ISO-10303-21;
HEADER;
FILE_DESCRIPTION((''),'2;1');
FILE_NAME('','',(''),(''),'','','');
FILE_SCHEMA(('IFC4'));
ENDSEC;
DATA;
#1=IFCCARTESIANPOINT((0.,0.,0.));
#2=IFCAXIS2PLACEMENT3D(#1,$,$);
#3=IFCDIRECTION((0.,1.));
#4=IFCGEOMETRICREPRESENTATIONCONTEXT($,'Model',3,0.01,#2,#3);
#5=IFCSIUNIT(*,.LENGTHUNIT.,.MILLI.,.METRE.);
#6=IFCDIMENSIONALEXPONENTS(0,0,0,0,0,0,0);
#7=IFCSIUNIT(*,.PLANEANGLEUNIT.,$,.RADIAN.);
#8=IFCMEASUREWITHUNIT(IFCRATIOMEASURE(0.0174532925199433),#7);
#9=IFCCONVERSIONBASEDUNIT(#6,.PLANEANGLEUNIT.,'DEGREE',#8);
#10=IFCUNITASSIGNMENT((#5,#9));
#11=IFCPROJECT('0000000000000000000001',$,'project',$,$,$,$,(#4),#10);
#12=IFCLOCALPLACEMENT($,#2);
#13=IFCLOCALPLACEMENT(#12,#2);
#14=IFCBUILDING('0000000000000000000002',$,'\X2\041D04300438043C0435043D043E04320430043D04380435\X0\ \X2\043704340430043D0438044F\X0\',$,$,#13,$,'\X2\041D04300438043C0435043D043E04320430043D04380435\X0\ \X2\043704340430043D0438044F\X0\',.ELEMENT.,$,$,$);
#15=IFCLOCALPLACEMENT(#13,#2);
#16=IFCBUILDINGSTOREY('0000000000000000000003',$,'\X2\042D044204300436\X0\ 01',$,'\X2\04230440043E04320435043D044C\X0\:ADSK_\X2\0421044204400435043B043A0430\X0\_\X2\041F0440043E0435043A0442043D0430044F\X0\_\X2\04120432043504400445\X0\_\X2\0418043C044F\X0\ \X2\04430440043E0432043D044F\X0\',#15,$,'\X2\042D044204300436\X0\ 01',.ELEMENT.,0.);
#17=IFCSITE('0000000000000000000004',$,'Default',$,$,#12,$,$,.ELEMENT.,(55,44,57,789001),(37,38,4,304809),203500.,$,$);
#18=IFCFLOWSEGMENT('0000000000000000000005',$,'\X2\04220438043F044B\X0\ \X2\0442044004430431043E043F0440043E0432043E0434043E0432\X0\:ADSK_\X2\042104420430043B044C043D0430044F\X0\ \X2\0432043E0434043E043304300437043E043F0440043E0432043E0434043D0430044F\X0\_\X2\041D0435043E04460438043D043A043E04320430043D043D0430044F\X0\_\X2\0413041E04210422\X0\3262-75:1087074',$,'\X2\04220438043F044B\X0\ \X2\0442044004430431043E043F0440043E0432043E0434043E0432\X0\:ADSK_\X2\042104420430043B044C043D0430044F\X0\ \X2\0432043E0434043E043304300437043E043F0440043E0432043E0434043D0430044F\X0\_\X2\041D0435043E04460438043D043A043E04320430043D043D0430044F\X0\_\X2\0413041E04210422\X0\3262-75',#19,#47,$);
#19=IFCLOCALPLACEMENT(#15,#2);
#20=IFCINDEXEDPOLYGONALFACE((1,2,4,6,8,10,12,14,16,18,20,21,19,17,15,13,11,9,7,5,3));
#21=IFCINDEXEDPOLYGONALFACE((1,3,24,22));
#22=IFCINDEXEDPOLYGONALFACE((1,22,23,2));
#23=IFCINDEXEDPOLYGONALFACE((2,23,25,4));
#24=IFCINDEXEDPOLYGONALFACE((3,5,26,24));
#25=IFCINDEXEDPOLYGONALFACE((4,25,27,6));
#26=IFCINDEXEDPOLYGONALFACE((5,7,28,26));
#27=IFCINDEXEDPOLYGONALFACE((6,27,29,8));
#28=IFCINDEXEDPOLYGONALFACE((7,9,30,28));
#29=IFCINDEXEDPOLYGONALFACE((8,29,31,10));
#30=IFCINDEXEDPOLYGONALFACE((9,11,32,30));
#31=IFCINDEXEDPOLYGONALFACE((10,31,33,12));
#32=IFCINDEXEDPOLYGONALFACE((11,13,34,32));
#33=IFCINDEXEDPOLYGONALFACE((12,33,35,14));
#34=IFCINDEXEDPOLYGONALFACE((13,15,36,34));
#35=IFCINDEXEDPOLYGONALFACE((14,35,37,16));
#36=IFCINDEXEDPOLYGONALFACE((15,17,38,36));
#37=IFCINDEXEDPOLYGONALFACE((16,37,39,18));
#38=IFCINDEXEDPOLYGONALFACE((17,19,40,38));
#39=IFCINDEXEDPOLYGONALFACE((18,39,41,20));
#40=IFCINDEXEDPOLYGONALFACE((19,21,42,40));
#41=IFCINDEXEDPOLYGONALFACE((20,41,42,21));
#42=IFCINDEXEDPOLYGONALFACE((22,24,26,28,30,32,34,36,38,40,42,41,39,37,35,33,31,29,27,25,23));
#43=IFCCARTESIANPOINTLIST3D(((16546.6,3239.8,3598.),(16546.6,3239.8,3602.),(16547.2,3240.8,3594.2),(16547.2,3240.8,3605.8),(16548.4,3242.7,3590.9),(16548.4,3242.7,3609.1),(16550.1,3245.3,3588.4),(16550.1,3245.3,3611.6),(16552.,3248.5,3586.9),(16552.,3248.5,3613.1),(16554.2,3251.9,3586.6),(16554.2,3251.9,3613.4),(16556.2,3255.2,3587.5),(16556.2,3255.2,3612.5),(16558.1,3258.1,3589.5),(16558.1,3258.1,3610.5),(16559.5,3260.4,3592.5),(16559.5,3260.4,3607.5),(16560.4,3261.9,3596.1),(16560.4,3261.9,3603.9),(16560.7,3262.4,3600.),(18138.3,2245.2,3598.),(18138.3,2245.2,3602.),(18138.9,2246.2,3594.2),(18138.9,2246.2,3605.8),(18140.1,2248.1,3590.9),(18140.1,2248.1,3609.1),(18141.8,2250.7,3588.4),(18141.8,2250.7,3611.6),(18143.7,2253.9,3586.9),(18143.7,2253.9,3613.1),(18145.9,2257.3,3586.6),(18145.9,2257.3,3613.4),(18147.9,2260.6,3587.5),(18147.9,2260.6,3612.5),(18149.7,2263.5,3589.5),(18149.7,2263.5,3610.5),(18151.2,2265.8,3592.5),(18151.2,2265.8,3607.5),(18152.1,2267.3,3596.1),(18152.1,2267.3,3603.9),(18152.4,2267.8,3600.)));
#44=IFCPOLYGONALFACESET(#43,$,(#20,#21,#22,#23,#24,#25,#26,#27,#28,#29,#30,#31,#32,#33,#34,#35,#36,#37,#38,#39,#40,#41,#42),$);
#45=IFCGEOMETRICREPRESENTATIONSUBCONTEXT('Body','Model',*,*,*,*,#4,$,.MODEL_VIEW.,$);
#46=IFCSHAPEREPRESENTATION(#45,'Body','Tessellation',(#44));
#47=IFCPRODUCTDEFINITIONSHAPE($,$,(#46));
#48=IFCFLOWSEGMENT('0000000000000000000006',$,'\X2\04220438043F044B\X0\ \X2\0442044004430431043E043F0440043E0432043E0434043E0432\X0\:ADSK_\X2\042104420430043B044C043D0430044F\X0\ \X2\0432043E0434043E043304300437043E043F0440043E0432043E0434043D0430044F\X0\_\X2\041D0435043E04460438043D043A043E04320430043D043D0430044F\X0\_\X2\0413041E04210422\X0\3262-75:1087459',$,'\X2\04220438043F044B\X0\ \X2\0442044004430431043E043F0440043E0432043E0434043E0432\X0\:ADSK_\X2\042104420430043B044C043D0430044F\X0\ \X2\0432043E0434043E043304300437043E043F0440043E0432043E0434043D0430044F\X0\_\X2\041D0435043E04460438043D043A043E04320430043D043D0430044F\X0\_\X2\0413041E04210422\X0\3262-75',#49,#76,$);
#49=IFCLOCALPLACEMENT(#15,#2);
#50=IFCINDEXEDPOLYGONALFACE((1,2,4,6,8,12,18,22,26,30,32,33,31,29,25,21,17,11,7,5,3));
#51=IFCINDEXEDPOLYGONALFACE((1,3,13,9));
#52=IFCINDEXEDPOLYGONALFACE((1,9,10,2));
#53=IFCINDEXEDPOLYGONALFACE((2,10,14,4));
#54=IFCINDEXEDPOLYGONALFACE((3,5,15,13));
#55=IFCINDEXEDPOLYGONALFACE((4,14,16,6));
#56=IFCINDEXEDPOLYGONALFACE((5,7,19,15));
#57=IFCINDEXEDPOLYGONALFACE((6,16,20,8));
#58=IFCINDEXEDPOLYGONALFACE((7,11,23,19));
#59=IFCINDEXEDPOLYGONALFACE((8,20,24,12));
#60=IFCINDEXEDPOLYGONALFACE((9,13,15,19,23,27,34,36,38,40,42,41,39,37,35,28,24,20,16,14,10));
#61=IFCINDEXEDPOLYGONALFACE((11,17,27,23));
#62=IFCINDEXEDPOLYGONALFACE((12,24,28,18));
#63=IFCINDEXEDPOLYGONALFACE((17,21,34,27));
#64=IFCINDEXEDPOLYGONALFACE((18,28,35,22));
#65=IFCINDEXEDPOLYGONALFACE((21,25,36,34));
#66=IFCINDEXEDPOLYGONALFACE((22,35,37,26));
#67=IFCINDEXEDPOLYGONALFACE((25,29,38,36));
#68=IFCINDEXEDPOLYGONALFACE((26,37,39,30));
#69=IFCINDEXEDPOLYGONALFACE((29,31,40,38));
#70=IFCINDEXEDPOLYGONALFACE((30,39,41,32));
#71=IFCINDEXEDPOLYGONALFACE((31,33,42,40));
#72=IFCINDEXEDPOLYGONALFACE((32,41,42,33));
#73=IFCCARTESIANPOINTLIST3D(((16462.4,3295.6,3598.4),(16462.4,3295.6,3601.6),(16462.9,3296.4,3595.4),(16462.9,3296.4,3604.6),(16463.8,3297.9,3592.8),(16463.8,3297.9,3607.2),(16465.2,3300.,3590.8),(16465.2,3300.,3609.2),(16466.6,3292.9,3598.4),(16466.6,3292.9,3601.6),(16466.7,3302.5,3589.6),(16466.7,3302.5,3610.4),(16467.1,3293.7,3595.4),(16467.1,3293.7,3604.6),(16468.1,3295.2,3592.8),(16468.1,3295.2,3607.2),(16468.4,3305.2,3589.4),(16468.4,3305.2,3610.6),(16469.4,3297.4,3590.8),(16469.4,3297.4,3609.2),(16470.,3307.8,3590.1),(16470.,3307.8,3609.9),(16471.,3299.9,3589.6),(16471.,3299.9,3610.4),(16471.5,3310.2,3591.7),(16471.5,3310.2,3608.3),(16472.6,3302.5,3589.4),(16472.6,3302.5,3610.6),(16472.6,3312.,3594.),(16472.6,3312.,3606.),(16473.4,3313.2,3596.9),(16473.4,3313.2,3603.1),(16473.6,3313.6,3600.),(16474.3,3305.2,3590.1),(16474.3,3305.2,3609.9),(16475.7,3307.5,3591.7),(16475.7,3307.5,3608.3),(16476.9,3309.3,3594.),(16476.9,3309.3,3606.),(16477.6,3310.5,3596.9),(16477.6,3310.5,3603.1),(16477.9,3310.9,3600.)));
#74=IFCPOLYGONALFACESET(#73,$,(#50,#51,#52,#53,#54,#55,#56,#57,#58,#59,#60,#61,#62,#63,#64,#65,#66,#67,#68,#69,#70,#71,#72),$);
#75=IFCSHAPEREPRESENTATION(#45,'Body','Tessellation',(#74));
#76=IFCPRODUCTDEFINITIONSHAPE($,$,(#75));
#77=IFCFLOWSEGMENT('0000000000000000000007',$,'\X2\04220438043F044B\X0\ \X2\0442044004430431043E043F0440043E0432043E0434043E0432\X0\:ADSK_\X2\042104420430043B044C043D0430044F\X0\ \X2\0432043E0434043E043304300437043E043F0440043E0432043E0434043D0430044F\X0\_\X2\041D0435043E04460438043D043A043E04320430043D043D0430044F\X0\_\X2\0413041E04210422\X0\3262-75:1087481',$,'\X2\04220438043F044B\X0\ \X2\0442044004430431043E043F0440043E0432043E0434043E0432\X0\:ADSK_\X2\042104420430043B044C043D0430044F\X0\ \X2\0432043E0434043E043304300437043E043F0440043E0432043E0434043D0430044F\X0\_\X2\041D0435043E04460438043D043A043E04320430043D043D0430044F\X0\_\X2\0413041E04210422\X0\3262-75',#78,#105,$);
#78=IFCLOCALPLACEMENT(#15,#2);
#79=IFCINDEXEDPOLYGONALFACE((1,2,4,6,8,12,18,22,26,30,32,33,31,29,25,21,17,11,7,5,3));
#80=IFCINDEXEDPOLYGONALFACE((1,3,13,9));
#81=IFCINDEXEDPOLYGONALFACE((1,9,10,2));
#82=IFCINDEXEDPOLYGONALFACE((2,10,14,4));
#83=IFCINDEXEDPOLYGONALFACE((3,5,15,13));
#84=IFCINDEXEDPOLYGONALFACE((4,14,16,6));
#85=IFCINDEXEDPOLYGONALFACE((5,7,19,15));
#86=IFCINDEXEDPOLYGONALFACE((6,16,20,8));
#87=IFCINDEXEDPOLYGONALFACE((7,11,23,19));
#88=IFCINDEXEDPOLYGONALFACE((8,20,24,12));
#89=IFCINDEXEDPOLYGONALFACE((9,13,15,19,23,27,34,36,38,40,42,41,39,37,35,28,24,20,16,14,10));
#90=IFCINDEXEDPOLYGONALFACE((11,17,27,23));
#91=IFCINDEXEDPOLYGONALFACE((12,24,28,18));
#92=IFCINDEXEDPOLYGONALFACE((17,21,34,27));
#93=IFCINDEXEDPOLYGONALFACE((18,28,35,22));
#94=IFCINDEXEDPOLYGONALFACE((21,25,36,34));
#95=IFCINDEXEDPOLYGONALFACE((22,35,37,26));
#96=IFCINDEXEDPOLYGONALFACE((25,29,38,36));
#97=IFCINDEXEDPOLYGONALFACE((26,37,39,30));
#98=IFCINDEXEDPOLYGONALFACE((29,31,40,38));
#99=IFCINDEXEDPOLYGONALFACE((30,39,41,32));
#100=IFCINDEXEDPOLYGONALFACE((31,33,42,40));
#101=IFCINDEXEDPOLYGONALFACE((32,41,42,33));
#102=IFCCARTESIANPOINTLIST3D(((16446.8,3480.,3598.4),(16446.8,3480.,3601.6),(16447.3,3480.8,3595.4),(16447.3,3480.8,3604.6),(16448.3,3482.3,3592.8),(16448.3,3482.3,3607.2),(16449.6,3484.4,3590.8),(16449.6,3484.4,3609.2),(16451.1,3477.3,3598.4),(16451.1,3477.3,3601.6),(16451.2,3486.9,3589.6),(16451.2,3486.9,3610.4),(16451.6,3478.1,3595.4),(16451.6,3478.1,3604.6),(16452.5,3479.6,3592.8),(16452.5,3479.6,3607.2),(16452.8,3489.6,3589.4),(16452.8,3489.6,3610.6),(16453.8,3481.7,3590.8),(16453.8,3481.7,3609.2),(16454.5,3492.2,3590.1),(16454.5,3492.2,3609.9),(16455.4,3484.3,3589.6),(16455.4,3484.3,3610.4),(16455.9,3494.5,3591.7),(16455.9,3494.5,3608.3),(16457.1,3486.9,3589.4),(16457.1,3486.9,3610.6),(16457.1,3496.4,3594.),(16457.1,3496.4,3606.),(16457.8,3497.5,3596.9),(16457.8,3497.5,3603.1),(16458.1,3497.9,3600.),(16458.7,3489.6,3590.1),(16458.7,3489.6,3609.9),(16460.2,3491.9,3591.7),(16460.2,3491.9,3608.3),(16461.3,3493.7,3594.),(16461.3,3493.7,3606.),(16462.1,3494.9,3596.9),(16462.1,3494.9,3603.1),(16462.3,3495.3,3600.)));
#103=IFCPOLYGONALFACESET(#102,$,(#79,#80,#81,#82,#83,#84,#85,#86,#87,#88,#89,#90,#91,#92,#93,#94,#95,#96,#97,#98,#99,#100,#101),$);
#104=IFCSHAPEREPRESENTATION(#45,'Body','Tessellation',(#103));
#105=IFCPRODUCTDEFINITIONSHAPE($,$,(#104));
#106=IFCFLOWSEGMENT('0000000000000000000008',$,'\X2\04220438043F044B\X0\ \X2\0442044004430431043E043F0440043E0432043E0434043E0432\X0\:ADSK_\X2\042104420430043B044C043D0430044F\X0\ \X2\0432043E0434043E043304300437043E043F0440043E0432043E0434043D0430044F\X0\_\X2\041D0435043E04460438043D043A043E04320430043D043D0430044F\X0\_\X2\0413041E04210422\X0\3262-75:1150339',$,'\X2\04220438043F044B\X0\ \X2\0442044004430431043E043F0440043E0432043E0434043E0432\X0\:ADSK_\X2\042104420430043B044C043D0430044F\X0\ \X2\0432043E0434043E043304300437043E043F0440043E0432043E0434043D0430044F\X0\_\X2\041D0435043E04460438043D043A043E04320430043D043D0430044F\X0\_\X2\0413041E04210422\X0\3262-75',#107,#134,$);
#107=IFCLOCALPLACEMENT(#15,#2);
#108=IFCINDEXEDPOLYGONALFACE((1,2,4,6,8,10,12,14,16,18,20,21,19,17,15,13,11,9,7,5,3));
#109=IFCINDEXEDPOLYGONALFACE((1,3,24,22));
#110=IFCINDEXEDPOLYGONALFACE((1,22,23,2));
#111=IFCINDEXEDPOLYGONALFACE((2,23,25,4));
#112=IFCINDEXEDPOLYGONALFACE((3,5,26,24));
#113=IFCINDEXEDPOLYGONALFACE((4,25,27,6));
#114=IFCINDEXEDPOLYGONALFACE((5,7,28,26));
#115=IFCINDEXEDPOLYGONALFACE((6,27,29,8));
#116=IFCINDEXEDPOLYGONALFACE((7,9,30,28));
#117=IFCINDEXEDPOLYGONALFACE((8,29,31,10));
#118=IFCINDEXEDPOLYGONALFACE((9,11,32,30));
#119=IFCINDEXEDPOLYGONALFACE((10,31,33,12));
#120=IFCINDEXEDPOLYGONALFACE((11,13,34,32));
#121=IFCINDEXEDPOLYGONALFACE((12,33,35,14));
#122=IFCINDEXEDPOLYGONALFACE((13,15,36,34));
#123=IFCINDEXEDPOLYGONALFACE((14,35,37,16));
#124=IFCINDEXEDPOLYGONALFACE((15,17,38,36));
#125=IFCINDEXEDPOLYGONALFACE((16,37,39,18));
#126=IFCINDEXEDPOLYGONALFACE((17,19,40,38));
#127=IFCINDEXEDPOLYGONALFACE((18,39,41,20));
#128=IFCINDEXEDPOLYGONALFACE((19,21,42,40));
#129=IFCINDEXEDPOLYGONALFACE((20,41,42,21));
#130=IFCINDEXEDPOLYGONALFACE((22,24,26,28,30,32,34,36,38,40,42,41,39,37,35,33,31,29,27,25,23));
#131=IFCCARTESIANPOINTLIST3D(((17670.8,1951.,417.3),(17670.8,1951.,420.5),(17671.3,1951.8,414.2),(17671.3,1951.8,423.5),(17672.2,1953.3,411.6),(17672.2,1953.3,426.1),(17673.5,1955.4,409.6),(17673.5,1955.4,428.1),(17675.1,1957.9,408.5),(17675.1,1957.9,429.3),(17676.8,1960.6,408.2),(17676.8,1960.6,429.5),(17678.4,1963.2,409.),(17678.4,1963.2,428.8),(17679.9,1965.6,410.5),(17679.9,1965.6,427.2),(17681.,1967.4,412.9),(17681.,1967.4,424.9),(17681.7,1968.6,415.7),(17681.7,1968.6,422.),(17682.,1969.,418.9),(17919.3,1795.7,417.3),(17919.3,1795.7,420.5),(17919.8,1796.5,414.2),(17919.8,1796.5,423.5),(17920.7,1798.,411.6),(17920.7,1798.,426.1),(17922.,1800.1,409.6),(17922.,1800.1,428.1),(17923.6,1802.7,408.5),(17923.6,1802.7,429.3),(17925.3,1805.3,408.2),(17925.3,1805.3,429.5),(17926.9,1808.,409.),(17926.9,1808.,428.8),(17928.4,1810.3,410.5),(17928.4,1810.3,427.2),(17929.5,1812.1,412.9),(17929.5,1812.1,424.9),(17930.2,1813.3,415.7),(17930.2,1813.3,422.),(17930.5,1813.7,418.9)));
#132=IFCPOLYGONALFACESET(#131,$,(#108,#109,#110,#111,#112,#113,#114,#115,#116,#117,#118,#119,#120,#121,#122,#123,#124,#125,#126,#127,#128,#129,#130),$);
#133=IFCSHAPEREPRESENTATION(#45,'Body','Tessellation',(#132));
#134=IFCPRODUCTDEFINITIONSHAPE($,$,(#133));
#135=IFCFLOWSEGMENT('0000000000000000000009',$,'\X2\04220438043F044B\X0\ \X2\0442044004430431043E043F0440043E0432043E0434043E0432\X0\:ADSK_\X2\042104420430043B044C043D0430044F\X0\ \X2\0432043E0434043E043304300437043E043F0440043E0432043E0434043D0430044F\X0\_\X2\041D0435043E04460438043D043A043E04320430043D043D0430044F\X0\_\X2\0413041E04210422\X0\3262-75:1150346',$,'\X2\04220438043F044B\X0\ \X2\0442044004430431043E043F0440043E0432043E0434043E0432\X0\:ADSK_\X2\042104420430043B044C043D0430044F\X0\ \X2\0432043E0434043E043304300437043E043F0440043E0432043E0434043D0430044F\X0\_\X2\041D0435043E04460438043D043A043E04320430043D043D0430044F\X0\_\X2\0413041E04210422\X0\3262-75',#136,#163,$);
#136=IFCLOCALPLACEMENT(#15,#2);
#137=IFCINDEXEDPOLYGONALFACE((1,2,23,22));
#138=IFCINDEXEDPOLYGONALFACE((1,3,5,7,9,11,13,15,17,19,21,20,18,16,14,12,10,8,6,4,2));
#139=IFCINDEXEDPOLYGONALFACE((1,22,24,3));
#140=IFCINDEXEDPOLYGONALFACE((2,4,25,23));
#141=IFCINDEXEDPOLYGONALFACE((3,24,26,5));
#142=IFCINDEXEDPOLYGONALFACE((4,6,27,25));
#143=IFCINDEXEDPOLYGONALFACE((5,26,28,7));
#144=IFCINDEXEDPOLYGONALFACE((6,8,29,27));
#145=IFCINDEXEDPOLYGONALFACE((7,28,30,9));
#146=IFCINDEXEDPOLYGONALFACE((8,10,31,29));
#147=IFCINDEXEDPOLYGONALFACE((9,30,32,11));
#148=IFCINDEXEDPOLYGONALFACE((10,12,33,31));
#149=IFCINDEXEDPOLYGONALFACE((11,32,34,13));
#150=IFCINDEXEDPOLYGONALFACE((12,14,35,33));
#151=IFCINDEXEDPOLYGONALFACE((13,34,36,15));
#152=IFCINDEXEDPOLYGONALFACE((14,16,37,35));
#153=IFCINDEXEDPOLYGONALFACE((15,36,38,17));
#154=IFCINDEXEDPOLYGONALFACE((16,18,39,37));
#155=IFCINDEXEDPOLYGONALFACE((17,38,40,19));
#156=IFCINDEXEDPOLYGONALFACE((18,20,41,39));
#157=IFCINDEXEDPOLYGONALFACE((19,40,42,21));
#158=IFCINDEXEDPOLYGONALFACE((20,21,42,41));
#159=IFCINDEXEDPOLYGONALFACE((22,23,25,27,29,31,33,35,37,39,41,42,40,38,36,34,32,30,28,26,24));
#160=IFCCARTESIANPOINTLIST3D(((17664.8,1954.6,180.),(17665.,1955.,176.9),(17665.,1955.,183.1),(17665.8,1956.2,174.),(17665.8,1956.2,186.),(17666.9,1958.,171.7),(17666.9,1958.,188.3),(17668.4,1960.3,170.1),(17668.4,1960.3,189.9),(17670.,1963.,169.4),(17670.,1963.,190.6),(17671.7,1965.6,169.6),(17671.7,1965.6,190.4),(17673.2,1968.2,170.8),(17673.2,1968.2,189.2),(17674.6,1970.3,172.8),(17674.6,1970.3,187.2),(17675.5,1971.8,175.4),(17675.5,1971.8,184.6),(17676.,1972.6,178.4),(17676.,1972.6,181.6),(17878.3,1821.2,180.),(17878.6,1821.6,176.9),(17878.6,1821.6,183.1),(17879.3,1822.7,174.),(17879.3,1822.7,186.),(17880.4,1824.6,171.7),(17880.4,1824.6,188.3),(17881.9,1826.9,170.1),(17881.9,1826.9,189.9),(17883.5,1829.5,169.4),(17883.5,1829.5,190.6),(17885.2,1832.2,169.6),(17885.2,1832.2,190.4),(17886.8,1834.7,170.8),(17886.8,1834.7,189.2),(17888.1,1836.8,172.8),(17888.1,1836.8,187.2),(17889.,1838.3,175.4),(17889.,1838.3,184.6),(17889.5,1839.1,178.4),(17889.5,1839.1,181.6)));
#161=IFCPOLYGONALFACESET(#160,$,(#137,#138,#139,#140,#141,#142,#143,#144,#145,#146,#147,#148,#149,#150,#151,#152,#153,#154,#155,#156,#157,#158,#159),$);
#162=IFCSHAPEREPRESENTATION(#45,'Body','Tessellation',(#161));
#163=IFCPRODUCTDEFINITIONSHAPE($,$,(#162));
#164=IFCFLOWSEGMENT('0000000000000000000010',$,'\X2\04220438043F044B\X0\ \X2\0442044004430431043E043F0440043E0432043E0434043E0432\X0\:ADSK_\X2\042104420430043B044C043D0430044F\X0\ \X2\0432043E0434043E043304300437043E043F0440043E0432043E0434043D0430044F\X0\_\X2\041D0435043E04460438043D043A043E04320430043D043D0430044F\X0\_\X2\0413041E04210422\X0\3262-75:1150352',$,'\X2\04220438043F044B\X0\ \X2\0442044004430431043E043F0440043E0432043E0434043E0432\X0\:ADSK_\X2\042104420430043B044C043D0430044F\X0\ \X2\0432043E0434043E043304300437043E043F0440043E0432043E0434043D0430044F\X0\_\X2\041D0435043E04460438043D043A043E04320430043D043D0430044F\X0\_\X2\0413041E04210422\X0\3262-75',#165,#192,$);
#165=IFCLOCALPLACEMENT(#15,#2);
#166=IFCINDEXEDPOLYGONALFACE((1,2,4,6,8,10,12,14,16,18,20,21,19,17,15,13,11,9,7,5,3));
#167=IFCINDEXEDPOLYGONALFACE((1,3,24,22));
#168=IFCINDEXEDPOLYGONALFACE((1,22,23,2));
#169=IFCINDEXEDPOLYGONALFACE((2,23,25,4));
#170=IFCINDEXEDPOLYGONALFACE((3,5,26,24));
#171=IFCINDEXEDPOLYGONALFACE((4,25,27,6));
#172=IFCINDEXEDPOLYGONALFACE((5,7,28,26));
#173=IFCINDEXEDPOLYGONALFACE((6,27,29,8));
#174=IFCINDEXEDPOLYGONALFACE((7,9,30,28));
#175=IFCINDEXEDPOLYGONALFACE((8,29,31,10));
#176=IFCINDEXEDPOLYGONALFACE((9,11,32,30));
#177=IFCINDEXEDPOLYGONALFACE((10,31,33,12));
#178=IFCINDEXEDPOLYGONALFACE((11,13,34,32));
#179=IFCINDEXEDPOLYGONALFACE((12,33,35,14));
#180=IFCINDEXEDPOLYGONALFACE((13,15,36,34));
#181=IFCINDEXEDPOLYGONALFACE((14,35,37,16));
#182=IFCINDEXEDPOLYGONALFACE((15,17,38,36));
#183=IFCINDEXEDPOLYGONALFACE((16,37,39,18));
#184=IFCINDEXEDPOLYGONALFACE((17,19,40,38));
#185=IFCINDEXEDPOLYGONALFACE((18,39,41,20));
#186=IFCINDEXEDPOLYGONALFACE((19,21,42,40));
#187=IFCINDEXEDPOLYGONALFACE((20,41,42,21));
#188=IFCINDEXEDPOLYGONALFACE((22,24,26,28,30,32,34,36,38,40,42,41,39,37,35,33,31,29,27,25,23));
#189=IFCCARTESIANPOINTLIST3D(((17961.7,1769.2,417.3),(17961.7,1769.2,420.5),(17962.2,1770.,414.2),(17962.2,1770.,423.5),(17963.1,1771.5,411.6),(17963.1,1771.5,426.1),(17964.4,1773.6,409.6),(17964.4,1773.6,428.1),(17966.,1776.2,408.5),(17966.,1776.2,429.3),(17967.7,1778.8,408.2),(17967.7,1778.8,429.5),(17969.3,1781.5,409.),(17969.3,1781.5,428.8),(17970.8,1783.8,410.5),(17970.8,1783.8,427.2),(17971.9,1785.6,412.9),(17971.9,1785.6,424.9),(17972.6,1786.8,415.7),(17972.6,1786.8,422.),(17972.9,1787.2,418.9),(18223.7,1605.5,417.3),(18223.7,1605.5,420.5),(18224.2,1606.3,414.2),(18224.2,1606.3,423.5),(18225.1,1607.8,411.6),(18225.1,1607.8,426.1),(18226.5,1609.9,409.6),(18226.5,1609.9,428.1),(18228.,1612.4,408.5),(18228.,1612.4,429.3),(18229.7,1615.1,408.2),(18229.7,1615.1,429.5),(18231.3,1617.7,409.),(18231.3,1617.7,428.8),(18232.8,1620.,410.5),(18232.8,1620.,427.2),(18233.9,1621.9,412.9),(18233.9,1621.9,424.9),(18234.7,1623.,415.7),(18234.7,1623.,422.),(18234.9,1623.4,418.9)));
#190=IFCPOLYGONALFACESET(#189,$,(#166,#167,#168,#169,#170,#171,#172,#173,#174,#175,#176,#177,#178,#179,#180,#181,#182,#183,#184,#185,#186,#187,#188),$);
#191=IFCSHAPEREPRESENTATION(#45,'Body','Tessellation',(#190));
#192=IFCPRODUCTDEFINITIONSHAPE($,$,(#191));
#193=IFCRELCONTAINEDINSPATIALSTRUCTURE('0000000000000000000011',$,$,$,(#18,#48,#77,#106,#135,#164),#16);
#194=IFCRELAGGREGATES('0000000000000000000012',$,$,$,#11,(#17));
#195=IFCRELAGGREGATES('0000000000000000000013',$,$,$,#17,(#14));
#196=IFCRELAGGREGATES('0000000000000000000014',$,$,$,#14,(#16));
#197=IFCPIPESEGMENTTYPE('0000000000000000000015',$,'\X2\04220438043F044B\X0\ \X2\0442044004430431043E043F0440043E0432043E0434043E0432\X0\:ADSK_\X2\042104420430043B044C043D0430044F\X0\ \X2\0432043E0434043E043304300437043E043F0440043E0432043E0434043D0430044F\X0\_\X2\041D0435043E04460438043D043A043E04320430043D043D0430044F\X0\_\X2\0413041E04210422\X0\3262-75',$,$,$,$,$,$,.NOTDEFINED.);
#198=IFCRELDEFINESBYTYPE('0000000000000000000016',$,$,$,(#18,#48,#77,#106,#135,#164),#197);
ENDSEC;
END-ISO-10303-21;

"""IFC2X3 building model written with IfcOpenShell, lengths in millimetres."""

from ifc_helpers import new_model, entity, si_unit, converted_unit, direction, frame, origin, origin_2d_with_axis, place, context, subcontext, project, spatial, circle, extrude, type_object, element, save


model = new_model("IFC2X3")

# Units and contexts
model_context = context("Model", 3, precision=0.01, world=origin(), true_north=direction((0.0, 1.0)))
body_context = subcontext(model_context, "Body", "Model", "MODEL_VIEW")
ifc_project = project(units=[si_unit("LENGTHUNIT", "METRE", prefix="MILLI"), converted_unit("PLANEANGLEUNIT", "DEGREE", entity("IfcRatioMeasure", 0.0174532925199433), si_unit("PLANEANGLEUNIT", "RADIAN"), dimensions=[0, 0, 0, 0, 0, 0, 0])], contexts=[model_context])

# Site, building, storey
site_placement = place(None, origin())
site = spatial("IfcSite", under=ifc_project, at=site_placement, Name="Default", CompositionType="ELEMENT", RefLatitude=(55, 44, 57, 789001), RefLongitude=(37, 38, 4, 304809), RefElevation=203500.0)
building_placement = place(site_placement, origin())
building = spatial("IfcBuilding", under=site, at=building_placement, Name="Наименование здания", LongName="Наименование здания", CompositionType="ELEMENT")
storey_placement = place(building_placement, origin())
storey = spatial("IfcBuildingStorey", under=building, at=storey_placement, Name="Этаж 01", ObjectType="Уровень:ADSK_Стрелка_Проектная_Вверх_Имя уровня", LongName="Этаж 01", CompositionType="ELEMENT", Elevation=0.0)

# Flow segments
pipe_segment_type = type_object("IfcPipeSegmentType", Name="Типы трубопроводов:ADSK_Стальная водогазопроводная_Неоцинкованная_ГОСТ3262-75", PredefinedType="NOTDEFINED")
flow_segment_1_placement = place(storey_placement, frame((16544.9, 2243.5, 3585.0)))
element("IfcFlowSegment", 1, at=flow_segment_1_placement, inside=storey, type_object=pipe_segment_type, Name="Типы трубопроводов:ADSK_Стальная водогазопроводная_Неоцинкованная_ГОСТ3262-75:1087074", ObjectType="Типы трубопроводов:ADSK_Стальная водогазопроводная_Неоцинкованная_ГОСТ3262-75", context=body_context, shape_type="SweptSolid", body=[
    extrude(circle(Radius=13.4, at=origin_2d_with_axis()), frame((1600.4, 13.0, 15.0), z_axis=(-0.848053, 0.529912, 0.0), x_axis=(0.529912, 0.848053, 0.0)), (0.0, 0.0, 1.0), 1876.9),
])
flow_segment_2_placement = place(storey_placement, frame((16460.7, 3291.2, 3587.8)))
element("IfcFlowSegment", 2, at=flow_segment_2_placement, inside=storey, type_object=pipe_segment_type, Name="Типы трубопроводов:ADSK_Стальная водогазопроводная_Неоцинкованная_ГОСТ3262-75:1087459", ObjectType="Типы трубопроводов:ADSK_Стальная водогазопроводная_Неоцинкованная_ГОСТ3262-75", context=body_context, shape_type="SweptSolid", body=[
    extrude(circle(Radius=10.7, at=origin_2d_with_axis()), frame((7.2, 13.3, 12.2), z_axis=(0.848053, -0.529912, 0.0), x_axis=(0.529912, 0.848053, 0.0)), (0.0, 0.0, 1.0), 5.0),
])
flow_segment_3_placement = place(storey_placement, frame((16445.2, 3475.6, 3587.8)))
element("IfcFlowSegment", 3, at=flow_segment_3_placement, inside=storey, type_object=pipe_segment_type, Name="Типы трубопроводов:ADSK_Стальная водогазопроводная_Неоцинкованная_ГОСТ3262-75:1087481", ObjectType="Типы трубопроводов:ADSK_Стальная водогазопроводная_Неоцинкованная_ГОСТ3262-75", context=body_context, shape_type="SweptSolid", body=[
    extrude(circle(Radius=10.7, at=origin_2d_with_axis()), frame((11.5, 10.6, 12.2), z_axis=(-0.848053, 0.529912, 0.0), x_axis=(0.529912, 0.848053, 0.0)), (0.0, 0.0, 1.0), 5.0),
])
flow_segment_4_placement = place(storey_placement, frame((17669.1, 1794.0, 406.6)))
element("IfcFlowSegment", 4, at=flow_segment_4_placement, inside=storey, type_object=pipe_segment_type, Name="Типы трубопроводов:ADSK_Стальная водогазопроводная_Неоцинкованная_ГОСТ3262-75:1150339", ObjectType="Типы трубопроводов:ADSK_Стальная водогазопроводная_Неоцинкованная_ГОСТ3262-75", context=body_context, shape_type="SweptSolid", body=[
    extrude(circle(Radius=10.7, at=origin_2d_with_axis()), frame((255.7, 10.6, 12.2), z_axis=(-0.848049, 0.529918, 0.0), x_axis=(0.529918, 0.848049, 0.0)), (0.0, 0.0, 1.0), 293.0),
])
flow_segment_5_placement = place(storey_placement, frame((17663.2, 1819.6, 167.8)))
element("IfcFlowSegment", 5, at=flow_segment_5_placement, inside=storey, type_object=pipe_segment_type, Name="Типы трубопроводов:ADSK_Стальная водогазопроводная_Неоцинкованная_ГОСТ3262-75:1150346", ObjectType="Типы трубопроводов:ADSK_Стальная водогазопроводная_Неоцинкованная_ГОСТ3262-75", context=body_context, shape_type="SweptSolid", body=[
    extrude(circle(Radius=10.7, at=origin_2d_with_axis()), frame((7.2, 144.1, 12.2), z_axis=(0.848048, -0.529919, 0.0), x_axis=(-0.529919, -0.848048, 0.0)), (0.0, 0.0, 1.0), 251.8),
])
flow_segment_6_placement = place(storey_placement, frame((17960.0, 1603.8, 406.6)))
element("IfcFlowSegment", 6, at=flow_segment_6_placement, inside=storey, type_object=pipe_segment_type, Name="Типы трубопроводов:ADSK_Стальная водогазопроводная_Неоцинкованная_ГОСТ3262-75:1150352", ObjectType="Типы трубопроводов:ADSK_Стальная водогазопроводная_Неоцинкованная_ГОСТ3262-75", context=body_context, shape_type="SweptSolid", body=[
    extrude(circle(Radius=10.7, at=origin_2d_with_axis()), frame((7.2, 174.4, 12.2), z_axis=(0.848048, -0.52992, 0.0), x_axis=(0.52992, 0.848048, 0.0)), (0.0, 0.0, 1.0), 309.0),
])

save(model, "model.ifc")
